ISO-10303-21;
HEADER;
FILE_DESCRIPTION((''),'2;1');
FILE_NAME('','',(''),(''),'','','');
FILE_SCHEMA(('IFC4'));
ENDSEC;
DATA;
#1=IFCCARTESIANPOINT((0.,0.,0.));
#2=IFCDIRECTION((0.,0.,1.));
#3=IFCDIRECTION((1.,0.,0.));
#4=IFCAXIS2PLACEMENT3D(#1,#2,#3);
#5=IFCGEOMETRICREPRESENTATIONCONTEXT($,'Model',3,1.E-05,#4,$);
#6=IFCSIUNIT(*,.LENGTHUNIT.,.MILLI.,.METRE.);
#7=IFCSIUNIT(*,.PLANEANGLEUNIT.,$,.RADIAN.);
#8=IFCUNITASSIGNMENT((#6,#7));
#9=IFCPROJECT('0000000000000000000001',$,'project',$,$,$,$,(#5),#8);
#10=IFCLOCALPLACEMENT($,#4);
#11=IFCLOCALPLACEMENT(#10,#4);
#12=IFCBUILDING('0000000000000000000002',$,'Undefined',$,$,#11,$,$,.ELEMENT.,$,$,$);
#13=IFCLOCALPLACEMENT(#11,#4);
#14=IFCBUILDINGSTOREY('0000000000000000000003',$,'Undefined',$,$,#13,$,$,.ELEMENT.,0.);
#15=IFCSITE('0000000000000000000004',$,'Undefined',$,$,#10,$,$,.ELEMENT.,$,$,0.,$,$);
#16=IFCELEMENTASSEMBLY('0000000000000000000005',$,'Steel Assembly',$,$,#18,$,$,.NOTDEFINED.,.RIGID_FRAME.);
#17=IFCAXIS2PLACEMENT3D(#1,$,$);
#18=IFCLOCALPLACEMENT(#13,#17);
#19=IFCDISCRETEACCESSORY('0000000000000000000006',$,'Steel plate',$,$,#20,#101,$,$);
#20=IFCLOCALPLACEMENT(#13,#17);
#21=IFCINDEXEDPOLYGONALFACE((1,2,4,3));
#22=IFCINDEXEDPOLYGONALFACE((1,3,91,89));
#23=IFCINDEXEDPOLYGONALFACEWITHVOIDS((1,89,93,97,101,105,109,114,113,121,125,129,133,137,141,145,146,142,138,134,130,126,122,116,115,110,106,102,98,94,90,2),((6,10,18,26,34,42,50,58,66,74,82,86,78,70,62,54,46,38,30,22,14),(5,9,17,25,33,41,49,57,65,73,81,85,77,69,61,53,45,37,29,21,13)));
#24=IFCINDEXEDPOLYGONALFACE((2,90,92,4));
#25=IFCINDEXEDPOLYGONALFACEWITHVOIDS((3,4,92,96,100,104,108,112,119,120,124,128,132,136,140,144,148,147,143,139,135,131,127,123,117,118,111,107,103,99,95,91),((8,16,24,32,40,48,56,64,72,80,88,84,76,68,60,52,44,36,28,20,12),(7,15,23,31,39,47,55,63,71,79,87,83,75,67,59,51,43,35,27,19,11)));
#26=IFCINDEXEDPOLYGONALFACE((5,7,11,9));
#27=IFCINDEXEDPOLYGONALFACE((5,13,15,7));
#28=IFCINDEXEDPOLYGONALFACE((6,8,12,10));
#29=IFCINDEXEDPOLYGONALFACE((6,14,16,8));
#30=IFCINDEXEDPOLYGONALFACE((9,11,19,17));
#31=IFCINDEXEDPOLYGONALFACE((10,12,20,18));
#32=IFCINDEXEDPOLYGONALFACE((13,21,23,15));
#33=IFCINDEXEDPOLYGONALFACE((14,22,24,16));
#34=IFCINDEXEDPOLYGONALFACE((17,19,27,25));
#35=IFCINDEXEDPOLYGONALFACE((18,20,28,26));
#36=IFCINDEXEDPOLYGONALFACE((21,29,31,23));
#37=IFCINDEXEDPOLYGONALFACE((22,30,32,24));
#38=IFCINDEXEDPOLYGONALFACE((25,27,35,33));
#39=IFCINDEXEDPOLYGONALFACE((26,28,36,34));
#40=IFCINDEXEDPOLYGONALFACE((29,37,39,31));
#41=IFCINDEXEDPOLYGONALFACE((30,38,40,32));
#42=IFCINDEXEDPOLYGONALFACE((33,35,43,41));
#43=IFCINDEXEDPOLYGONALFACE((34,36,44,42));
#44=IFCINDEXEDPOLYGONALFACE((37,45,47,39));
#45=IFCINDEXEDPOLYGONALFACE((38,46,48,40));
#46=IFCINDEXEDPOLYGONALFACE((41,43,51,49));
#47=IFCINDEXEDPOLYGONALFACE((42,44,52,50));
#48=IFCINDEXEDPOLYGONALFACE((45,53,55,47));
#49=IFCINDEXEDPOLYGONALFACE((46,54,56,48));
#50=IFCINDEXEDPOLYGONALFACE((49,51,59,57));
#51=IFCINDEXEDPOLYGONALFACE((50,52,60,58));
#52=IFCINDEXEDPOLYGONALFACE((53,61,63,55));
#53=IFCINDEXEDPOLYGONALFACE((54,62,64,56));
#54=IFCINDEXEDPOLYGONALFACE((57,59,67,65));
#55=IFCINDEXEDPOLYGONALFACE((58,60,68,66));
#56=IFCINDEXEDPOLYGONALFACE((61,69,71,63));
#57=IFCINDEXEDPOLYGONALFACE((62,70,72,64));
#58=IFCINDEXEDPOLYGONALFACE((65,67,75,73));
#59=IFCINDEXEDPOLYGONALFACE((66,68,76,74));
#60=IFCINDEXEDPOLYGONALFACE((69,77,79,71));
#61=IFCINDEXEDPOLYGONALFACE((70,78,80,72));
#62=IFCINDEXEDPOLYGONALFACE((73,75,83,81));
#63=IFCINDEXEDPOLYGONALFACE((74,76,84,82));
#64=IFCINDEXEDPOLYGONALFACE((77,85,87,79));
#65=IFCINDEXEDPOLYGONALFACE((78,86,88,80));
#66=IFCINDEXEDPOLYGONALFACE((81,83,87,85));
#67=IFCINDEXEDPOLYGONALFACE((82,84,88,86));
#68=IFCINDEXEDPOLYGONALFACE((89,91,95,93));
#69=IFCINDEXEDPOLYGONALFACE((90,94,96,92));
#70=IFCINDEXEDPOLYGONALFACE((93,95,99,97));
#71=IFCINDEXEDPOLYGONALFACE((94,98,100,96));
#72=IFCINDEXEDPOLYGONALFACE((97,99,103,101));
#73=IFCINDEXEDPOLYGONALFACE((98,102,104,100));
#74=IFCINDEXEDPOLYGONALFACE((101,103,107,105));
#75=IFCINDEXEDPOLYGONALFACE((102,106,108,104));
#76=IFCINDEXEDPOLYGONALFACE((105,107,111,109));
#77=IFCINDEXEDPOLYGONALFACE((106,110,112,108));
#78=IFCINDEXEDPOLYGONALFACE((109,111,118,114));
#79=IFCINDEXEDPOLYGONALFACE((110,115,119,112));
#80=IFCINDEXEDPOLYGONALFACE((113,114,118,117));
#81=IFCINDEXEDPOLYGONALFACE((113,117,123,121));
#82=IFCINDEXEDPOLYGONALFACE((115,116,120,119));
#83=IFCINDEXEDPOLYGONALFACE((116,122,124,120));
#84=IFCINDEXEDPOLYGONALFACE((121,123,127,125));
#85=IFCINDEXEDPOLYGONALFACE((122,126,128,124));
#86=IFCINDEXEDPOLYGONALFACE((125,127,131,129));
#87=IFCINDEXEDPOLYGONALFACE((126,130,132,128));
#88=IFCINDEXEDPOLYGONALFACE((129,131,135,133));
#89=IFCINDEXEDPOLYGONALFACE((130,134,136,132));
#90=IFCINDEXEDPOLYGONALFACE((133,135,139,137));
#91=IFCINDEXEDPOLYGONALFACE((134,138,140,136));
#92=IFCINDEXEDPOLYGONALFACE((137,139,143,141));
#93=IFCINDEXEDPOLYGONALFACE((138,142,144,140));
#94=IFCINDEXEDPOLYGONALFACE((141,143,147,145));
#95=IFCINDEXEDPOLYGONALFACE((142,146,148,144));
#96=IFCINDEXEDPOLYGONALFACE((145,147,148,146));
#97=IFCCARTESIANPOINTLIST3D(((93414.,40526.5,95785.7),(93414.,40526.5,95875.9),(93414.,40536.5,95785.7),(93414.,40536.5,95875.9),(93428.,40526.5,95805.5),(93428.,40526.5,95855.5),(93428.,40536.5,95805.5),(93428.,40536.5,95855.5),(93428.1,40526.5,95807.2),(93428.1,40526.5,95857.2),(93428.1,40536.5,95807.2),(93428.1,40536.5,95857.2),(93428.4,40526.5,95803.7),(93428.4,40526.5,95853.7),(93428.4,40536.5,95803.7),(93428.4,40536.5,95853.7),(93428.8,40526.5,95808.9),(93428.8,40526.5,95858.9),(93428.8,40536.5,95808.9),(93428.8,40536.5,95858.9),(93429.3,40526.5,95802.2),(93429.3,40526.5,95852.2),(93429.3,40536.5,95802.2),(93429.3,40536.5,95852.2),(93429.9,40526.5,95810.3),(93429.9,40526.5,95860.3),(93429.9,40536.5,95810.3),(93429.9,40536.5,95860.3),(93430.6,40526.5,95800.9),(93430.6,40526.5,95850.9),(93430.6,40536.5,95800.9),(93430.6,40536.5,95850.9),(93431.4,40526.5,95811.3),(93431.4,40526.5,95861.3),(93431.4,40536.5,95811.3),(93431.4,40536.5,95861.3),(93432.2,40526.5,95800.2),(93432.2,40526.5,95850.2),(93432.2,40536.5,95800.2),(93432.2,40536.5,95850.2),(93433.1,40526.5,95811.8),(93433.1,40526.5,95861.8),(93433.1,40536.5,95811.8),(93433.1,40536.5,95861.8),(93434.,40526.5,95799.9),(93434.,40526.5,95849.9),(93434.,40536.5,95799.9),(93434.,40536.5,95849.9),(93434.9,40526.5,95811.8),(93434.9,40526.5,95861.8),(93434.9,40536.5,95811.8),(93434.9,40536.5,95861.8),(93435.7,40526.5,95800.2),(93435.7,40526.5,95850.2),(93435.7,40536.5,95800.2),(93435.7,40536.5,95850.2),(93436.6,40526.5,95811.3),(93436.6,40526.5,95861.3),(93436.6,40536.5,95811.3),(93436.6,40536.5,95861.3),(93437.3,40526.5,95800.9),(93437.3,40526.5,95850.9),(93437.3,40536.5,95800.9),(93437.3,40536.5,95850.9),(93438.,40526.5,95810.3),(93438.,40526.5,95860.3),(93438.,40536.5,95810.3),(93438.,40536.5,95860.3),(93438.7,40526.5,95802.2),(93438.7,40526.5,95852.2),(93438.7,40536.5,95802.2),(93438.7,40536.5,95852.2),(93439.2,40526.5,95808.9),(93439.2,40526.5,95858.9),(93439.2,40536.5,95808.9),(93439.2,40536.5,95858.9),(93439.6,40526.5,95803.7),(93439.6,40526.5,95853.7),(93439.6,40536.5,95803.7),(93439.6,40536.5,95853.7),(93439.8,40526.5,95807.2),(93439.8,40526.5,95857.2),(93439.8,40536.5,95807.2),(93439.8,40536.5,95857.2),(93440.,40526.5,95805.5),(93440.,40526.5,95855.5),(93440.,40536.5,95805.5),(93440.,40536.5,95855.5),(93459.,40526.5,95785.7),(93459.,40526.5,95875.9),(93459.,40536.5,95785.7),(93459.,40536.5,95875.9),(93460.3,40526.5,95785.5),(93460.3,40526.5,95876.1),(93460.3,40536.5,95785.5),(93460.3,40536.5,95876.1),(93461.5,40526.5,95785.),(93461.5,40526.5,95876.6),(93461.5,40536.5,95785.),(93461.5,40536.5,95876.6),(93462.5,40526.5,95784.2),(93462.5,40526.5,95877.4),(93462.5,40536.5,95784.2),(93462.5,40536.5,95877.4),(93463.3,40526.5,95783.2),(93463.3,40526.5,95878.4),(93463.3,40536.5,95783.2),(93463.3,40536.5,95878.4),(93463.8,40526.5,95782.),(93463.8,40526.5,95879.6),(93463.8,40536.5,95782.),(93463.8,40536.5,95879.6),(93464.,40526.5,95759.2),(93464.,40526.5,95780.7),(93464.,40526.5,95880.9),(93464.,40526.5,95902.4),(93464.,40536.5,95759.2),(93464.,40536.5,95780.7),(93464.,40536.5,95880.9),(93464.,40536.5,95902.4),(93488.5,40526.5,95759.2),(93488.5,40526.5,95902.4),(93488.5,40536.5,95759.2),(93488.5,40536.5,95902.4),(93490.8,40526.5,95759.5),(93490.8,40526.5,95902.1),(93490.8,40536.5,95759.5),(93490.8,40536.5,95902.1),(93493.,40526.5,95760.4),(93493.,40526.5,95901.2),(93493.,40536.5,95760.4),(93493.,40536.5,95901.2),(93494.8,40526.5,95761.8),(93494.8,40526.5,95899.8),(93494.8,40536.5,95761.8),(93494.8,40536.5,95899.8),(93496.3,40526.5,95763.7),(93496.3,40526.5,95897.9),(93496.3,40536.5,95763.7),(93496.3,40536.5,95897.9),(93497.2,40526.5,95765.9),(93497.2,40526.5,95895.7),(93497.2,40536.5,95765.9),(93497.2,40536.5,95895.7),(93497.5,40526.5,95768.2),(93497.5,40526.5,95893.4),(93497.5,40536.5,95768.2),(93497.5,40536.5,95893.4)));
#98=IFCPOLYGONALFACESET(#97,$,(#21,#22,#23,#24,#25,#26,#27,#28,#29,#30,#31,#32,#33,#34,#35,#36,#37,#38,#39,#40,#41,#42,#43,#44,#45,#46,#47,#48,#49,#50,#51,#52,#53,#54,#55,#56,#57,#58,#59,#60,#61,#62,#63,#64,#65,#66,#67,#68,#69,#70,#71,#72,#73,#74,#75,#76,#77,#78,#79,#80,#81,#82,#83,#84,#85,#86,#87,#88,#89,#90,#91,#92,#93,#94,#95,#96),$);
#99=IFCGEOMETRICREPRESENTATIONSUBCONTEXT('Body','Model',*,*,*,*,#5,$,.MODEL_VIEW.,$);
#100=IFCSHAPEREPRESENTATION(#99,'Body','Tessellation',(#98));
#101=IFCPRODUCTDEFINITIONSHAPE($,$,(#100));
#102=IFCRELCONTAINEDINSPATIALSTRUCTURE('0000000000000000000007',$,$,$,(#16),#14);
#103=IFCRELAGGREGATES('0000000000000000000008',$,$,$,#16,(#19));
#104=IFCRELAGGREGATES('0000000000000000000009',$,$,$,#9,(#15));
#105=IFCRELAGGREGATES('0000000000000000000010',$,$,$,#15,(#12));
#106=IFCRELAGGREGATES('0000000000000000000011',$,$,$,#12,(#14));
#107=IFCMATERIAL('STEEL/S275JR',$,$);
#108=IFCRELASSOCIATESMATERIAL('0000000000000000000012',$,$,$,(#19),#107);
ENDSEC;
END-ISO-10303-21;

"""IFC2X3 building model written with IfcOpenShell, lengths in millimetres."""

from ifc_helpers import new_model, si_unit, frame, frame_2d, origin_with_axes, origin_2d_with_axis, place, context, subcontext, project, spatial, polyline, circle_curve, parameter, trimmed, segment, composite_curve, circle, outline, extrude, source, transform, mapped, material, element, aggregate, save


model = new_model("IFC2X3")

# Units and contexts
model_context = context("Model", 3, precision=1e-05, world=origin_with_axes())
body_context = subcontext(model_context, "Body", "Model", "MODEL_VIEW")
ifc_project = project(units=[si_unit("LENGTHUNIT", "METRE", prefix="MILLI"), si_unit("PLANEANGLEUNIT", "RADIAN")], contexts=[model_context])

# Site, building, storey
site_placement = place(None, origin_with_axes())
site = spatial("IfcSite", under=ifc_project, at=site_placement, Name="Undefined", CompositionType="ELEMENT", RefElevation=0.0)
building_placement = place(site_placement, origin_with_axes())
building = spatial("IfcBuilding", under=site, at=building_placement, Name="Undefined", CompositionType="ELEMENT")
storey_placement = place(building_placement, origin_with_axes())
storey = spatial("IfcBuildingStorey", under=building, at=storey_placement, Name="Undefined", CompositionType="ELEMENT", Elevation=0.0)

# Shared definitions
ifc_material_1 = material(Name="STEEL/S275JR")

# Element assembly
assembly_1_placement = place(storey_placement, origin_with_axes())
assembly_1 = element("IfcElementAssembly", 1, at=assembly_1_placement, inside=storey, Name="Steel Assembly", AssemblyPlace="NOTDEFINED", PredefinedType="RIGID_FRAME")

# Discrete accessory, opening
discrete_accessory_1_placement = place(assembly_1_placement, frame((93464.0, 40531.5, 95902.4), z_axis=(0.0, 1.0, 0.0), x_axis=(1.0, 0.0, 0.0)))
discrete_accessory_1 = element("IfcDiscreteAccessory", 2, at=discrete_accessory_1_placement, material=ifc_material_1, Name="Steel plate", context=body_context, shape_type="SweptSolid", body=[
    extrude(outline(composite_curve([segment(polyline([(0.0, 0.0), (24.5, 0.0)]), True, "CONTINUOUS"), segment(trimmed(circle_curve(frame_2d((24.5, 9.0), x_axis=(0.0, -1.0)), 9.0), [parameter(0.0)], [parameter(1.570796)], True, "PARAMETER"), True, "CONTINUOUS"), segment(polyline([(33.5, 9.0), (33.5, 134.2)]), True, "CONTINUOUS"), segment(trimmed(circle_curve(frame_2d((24.5, 134.2), x_axis=(1.0, 0.0)), 9.0), [parameter(0.0)], [parameter(1.570796)], True, "PARAMETER"), True, "CONTINUOUS"), segment(polyline([(24.5, 143.2), (0.0, 143.2), (0.0, 121.7)]), True, "CONTINUOUS"), segment(trimmed(circle_curve(frame_2d((-5.0, 121.7), x_axis=(1.0, 0.0)), 5.0), [parameter(0.0)], [parameter(4.712389)], False, "PARAMETER"), True, "CONTINUOUS"), segment(polyline([(-5.0, 116.7), (-50.0, 116.7), (-50.0, 26.5), (-5.0, 26.5)]), True, "CONTINUOUS"), segment(trimmed(circle_curve(frame_2d((-5.0, 21.5), x_axis=(0.0, 1.0)), 5.0), [parameter(0.0)], [parameter(4.712389)], False, "PARAMETER"), True, "CONTINUOUS"), segment(polyline([(0.0, 21.5), (0.0, 0.0)]), True, "DISCONTINUOUS")], self_intersect=False)), frame((0.0, 0.0, -5.0), z_axis=(0.0, 0.0, 1.0), x_axis=(1.0, 0.0, 0.0)), (0.0, 0.0, 1.0), 10.0),
])
shared_shape_1 = source(origin_with_axes(), body_context, "Body", "SweptSolid", [
    extrude(circle(Radius=6.0, at=origin_2d_with_axis()), frame((0.0, -10.1, 0.0), z_axis=(0.0, 1.0, 0.0), x_axis=(1.0, 0.0, 0.0)), (0.0, 0.0, 1.0), 20.3),
])
opening_1_placement = place(assembly_1_placement, frame((93434.0, 40536.5, 95855.9), z_axis=(1.0, 0.0, 0.0), x_axis=(0.0, 0.0, -1.0)))
element("IfcOpeningElement", 3, at=opening_1_placement, cuts=discrete_accessory_1, ObjectType="Opening", context=body_context, shape_type="MappedRepresentation", body=[
    mapped(shared_shape_1, transform((0.0, 0.0, 0.0))),
    mapped(shared_shape_1, transform((50.0, 0.0, 0.0))),
])
aggregate(assembly_1, [discrete_accessory_1])

save(model, "model.ifc")
